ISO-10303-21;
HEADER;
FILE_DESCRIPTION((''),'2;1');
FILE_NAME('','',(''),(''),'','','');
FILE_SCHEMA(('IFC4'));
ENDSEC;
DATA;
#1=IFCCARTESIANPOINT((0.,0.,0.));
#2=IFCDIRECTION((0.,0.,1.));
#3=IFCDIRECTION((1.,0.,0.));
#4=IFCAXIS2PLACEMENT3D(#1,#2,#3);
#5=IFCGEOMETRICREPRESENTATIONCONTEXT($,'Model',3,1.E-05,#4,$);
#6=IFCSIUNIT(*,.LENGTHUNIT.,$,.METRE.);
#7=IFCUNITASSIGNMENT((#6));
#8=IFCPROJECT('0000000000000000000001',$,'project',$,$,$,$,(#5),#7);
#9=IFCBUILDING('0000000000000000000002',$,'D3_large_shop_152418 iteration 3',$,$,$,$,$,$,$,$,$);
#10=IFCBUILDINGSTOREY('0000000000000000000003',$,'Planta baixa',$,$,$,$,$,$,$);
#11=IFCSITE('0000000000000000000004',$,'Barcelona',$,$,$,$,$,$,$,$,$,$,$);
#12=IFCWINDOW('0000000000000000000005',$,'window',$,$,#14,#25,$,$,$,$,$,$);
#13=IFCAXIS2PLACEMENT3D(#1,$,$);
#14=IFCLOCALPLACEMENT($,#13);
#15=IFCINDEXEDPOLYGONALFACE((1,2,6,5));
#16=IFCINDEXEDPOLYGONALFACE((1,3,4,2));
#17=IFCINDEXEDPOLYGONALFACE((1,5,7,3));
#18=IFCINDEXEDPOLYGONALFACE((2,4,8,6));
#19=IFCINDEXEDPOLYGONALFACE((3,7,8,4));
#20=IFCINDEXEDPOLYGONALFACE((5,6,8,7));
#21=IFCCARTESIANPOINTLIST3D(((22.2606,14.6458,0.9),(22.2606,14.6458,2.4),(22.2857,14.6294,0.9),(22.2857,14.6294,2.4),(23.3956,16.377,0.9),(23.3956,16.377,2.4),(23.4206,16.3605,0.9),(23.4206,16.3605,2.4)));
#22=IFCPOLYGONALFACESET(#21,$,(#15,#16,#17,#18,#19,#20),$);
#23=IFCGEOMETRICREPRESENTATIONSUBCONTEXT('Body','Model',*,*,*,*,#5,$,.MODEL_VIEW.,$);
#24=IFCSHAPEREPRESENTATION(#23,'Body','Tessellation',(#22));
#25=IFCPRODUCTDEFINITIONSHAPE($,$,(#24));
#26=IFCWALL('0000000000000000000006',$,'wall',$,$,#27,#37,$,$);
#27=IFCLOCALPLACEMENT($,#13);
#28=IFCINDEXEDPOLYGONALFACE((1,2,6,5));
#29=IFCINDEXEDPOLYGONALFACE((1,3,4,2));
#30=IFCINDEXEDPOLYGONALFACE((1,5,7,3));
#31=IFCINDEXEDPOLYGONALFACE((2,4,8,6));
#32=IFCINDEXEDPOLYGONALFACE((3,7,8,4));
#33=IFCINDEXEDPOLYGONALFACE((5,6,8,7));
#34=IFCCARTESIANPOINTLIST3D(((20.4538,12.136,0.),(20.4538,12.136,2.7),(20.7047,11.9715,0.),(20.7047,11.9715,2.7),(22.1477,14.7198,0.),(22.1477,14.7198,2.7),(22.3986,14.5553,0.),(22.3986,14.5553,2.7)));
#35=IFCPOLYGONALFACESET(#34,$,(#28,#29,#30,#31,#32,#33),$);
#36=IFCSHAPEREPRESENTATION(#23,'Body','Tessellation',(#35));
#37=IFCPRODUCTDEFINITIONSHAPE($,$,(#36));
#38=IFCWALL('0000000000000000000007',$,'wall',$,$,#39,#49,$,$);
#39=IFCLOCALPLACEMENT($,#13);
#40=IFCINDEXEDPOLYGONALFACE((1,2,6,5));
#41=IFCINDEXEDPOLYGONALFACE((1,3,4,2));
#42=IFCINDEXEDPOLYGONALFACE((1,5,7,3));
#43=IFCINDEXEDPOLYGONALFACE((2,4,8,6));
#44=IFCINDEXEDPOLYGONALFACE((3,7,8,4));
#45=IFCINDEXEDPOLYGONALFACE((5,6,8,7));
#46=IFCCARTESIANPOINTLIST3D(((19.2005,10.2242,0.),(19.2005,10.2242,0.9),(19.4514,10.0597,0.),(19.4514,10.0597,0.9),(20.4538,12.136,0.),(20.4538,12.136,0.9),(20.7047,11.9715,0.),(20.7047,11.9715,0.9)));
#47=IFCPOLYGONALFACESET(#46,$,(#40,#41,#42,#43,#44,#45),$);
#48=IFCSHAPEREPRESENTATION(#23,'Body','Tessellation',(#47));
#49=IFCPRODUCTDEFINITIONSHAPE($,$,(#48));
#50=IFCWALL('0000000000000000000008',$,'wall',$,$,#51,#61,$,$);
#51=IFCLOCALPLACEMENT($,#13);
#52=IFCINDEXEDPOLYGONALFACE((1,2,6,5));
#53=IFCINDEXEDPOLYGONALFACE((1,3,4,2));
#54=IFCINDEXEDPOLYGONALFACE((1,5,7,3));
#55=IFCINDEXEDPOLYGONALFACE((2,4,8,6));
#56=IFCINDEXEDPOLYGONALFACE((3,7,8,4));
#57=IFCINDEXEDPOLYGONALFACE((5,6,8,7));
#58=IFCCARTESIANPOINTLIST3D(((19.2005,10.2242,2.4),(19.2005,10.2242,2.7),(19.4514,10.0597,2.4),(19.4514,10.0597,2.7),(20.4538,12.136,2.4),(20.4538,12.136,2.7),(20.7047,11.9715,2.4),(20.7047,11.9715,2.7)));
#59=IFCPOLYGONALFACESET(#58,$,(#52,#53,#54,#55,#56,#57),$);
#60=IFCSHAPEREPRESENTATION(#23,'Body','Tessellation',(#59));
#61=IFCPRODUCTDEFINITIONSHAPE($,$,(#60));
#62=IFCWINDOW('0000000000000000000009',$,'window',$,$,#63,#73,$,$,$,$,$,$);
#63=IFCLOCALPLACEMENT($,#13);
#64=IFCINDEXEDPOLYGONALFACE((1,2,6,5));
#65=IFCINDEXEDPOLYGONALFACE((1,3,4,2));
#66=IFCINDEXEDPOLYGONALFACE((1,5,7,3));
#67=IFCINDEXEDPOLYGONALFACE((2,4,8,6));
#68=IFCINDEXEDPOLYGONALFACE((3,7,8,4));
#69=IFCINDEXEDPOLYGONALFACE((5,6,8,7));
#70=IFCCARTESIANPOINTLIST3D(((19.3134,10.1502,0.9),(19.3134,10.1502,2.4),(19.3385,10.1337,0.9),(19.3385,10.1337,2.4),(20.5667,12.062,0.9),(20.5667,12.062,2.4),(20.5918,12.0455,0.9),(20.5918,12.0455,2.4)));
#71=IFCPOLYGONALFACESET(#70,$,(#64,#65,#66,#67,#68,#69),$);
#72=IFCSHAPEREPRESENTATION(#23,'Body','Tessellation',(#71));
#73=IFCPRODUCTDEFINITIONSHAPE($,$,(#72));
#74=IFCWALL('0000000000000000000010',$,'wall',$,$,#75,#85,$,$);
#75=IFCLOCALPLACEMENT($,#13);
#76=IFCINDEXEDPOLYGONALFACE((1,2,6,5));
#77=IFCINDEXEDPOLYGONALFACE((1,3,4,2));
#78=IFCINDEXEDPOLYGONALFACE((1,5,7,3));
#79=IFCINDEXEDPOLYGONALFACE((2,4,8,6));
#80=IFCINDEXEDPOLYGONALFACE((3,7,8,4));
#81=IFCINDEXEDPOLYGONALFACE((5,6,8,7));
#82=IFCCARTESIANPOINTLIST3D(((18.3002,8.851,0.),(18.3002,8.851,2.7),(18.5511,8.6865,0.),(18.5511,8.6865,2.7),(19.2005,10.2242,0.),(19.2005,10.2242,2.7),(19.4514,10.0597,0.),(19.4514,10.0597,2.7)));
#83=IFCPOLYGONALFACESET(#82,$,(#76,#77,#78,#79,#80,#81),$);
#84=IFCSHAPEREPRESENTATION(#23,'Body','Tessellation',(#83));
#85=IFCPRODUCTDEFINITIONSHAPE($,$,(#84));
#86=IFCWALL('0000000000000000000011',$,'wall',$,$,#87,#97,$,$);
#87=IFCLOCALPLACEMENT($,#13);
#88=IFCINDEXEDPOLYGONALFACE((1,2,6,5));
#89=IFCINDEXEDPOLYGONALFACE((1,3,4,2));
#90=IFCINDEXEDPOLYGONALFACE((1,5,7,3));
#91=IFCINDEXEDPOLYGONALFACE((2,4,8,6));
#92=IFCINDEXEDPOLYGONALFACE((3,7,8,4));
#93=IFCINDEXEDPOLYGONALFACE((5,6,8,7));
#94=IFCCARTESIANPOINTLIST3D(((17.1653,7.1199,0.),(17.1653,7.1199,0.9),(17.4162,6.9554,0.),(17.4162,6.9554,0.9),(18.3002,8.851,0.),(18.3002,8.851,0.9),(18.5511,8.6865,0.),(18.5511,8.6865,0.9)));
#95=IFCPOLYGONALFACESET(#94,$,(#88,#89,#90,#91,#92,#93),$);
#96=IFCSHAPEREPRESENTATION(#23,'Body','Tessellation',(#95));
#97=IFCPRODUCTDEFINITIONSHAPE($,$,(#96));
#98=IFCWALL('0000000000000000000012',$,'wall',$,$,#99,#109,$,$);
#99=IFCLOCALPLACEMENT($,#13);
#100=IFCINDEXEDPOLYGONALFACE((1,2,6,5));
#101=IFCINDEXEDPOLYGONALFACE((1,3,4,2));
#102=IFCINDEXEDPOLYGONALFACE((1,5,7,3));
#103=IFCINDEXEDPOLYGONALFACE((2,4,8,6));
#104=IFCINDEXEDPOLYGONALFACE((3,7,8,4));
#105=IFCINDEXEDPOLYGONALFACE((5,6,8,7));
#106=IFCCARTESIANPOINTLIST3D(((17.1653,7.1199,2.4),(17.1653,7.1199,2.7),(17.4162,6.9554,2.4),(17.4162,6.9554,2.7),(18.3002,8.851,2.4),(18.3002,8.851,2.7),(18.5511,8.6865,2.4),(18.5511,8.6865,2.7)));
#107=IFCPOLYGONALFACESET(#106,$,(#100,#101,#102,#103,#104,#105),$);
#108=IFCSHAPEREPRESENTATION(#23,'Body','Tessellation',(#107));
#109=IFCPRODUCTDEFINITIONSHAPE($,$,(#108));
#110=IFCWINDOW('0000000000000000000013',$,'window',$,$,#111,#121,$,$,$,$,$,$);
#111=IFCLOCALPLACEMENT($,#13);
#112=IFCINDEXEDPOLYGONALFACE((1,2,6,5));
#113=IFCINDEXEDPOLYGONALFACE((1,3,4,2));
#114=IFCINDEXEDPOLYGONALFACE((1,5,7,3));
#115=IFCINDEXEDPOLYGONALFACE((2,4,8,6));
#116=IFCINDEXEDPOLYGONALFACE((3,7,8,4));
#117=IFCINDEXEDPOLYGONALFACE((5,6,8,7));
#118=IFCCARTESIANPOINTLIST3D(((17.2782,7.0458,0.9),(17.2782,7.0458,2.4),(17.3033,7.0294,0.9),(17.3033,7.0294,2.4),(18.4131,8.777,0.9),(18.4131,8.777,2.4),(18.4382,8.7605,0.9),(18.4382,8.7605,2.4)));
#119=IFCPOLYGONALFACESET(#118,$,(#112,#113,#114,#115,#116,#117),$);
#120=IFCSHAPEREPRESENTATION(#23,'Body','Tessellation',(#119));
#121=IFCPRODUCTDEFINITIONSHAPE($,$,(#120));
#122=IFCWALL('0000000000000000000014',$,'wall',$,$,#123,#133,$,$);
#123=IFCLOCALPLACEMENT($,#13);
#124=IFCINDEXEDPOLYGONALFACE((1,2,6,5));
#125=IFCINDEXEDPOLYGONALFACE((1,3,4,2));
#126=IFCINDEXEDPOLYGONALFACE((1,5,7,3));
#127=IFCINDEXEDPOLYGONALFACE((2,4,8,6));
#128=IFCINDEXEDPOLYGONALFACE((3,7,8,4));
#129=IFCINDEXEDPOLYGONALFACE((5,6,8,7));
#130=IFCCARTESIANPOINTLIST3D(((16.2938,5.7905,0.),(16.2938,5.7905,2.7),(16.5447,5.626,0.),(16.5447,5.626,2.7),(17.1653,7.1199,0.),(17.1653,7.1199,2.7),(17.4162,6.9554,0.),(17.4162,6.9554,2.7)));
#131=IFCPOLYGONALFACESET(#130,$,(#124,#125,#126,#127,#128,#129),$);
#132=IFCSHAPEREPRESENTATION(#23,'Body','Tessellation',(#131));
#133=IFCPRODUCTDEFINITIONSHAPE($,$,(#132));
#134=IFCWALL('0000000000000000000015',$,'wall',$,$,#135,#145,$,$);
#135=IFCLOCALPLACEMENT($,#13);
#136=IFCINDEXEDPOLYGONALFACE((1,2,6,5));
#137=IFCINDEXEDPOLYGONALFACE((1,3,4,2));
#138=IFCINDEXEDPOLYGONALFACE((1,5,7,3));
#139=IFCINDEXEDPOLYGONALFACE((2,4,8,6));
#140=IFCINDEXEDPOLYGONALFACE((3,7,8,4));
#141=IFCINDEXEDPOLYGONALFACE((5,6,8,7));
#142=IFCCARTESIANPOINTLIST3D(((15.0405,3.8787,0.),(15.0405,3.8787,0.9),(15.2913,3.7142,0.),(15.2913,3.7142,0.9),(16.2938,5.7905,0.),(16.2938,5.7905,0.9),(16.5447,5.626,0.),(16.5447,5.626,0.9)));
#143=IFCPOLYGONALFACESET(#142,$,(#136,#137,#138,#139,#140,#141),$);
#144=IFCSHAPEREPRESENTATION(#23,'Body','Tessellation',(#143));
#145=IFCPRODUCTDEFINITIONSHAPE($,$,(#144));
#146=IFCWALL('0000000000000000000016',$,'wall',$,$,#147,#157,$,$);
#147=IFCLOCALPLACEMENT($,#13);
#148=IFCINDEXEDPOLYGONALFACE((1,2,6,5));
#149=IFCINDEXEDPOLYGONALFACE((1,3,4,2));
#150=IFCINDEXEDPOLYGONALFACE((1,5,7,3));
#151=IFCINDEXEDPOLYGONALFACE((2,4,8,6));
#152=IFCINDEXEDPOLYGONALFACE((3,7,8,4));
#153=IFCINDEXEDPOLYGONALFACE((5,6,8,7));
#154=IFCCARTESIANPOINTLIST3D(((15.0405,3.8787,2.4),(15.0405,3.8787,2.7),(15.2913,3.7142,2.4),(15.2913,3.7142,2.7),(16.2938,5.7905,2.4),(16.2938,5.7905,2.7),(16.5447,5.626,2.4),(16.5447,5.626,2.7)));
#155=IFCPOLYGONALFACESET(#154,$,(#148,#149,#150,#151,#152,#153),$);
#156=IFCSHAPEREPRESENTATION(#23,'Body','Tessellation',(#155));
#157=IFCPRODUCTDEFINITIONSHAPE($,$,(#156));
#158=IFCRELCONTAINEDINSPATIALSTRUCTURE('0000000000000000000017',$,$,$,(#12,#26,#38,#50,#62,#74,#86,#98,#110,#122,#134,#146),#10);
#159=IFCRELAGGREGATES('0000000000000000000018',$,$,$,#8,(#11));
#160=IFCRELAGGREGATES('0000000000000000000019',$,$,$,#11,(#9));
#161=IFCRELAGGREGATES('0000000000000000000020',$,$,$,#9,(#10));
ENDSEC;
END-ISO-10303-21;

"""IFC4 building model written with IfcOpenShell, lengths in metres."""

from ifc_helpers import new_model, si_unit, frame, origin, origin_with_axes, place, context, subcontext, project, spatial, polyline, outline, extrude, element, save


model = new_model("IFC4")

# Units and contexts
model_context = context("Model", 3, precision=1e-05, world=origin_with_axes())
body_context = subcontext(model_context, "Body", "Model", "MODEL_VIEW")
ifc_project = project(units=[si_unit("LENGTHUNIT", "METRE")], contexts=[model_context])

# Site, building, storey
site = spatial("IfcSite", under=ifc_project, Name="Barcelona")
building = spatial("IfcBuilding", under=site, Name="D3_large_shop_152418 iteration 3")
storey = spatial("IfcBuildingStorey", under=building, Name="Planta baixa")

# Window
window_1_placement = place(None, origin_with_axes())
element("IfcWindow", 1, at=window_1_placement, inside=storey, Name="window", context=body_context, shape_type="SweptSolid", body=[
    extrude(outline(polyline([(23.4206, 16.3605), (22.2857, 14.6294), (22.2606, 14.6458), (23.3956, 16.377), (23.4206, 16.3605)])), frame((0.0, 0.0, 0.9)), (0.0, 0.0, 1.0), 1.5),
])

# Walls
wall_1_placement = place(None, origin_with_axes())
element("IfcWall", 2, at=wall_1_placement, inside=storey, Name="wall", context=body_context, shape_type="SweptSolid", body=[
    extrude(outline(polyline([(22.3986, 14.5553), (20.7047, 11.9715), (20.4538, 12.136), (22.1477, 14.7198), (22.3986, 14.5553)])), origin(), (0.0, 0.0, 1.0), 2.7),
])
wall_2_placement = place(None, origin_with_axes())
element("IfcWall", 3, at=wall_2_placement, inside=storey, Name="wall", context=body_context, shape_type="SweptSolid", body=[
    extrude(outline(polyline([(20.7047, 11.9715), (19.4514, 10.0597), (19.2005, 10.2242), (20.4538, 12.136), (20.7047, 11.9715)])), origin(), (0.0, 0.0, 1.0), 0.9),
])
wall_3_placement = place(None, origin_with_axes())
element("IfcWall", 4, at=wall_3_placement, inside=storey, Name="wall", context=body_context, shape_type="SweptSolid", body=[
    extrude(outline(polyline([(20.7047, 11.9715), (19.4514, 10.0597), (19.2005, 10.2242), (20.4538, 12.136), (20.7047, 11.9715)])), frame((0.0, 0.0, 2.4)), (0.0, 0.0, 1.0), 0.3),
])

# Window
window_2_placement = place(None, origin_with_axes())
element("IfcWindow", 5, at=window_2_placement, inside=storey, Name="window", context=body_context, shape_type="SweptSolid", body=[
    extrude(outline(polyline([(20.5918, 12.0455), (19.3385, 10.1337), (19.3134, 10.1502), (20.5667, 12.062), (20.5918, 12.0455)])), frame((0.0, 0.0, 0.9)), (0.0, 0.0, 1.0), 1.5),
])

# Walls
wall_4_placement = place(None, origin_with_axes())
element("IfcWall", 6, at=wall_4_placement, inside=storey, Name="wall", context=body_context, shape_type="SweptSolid", body=[
    extrude(outline(polyline([(19.4514, 10.0597), (18.5511, 8.6865), (18.3002, 8.851), (19.2005, 10.2242), (19.4514, 10.0597)])), origin(), (0.0, 0.0, 1.0), 2.7),
])
wall_5_placement = place(None, origin_with_axes())
element("IfcWall", 7, at=wall_5_placement, inside=storey, Name="wall", context=body_context, shape_type="SweptSolid", body=[
    extrude(outline(polyline([(18.5511, 8.6865), (17.4162, 6.9554), (17.1653, 7.1199), (18.3002, 8.851), (18.5511, 8.6865)])), origin(), (0.0, 0.0, 1.0), 0.9),
])
wall_6_placement = place(None, origin_with_axes())
element("IfcWall", 8, at=wall_6_placement, inside=storey, Name="wall", context=body_context, shape_type="SweptSolid", body=[
    extrude(outline(polyline([(18.5511, 8.6865), (17.4162, 6.9554), (17.1653, 7.1199), (18.3002, 8.851), (18.5511, 8.6865)])), frame((0.0, 0.0, 2.4)), (0.0, 0.0, 1.0), 0.3),
])

# Window
window_3_placement = place(None, origin_with_axes())
element("IfcWindow", 9, at=window_3_placement, inside=storey, Name="window", context=body_context, shape_type="SweptSolid", body=[
    extrude(outline(polyline([(18.4382, 8.7605), (17.3033, 7.0294), (17.2782, 7.0458), (18.4131, 8.777), (18.4382, 8.7605)])), frame((0.0, 0.0, 0.9)), (0.0, 0.0, 1.0), 1.5),
])

# Walls
wall_7_placement = place(None, origin_with_axes())
element("IfcWall", 10, at=wall_7_placement, inside=storey, Name="wall", context=body_context, shape_type="SweptSolid", body=[
    extrude(outline(polyline([(17.4162, 6.9554), (16.5447, 5.626), (16.2938, 5.7905), (17.1653, 7.1199), (17.4162, 6.9554)])), origin(), (0.0, 0.0, 1.0), 2.7),
])
wall_8_placement = place(None, origin_with_axes())
element("IfcWall", 11, at=wall_8_placement, inside=storey, Name="wall", context=body_context, shape_type="SweptSolid", body=[
    extrude(outline(polyline([(16.5447, 5.626), (15.2913, 3.7142), (15.0405, 3.8787), (16.2938, 5.7905), (16.5447, 5.626)])), origin(), (0.0, 0.0, 1.0), 0.9),
])
wall_9_placement = place(None, origin_with_axes())
element("IfcWall", 12, at=wall_9_placement, inside=storey, Name="wall", context=body_context, shape_type="SweptSolid", body=[
    extrude(outline(polyline([(16.5447, 5.626), (15.2913, 3.7142), (15.0405, 3.8787), (16.2938, 5.7905), (16.5447, 5.626)])), frame((0.0, 0.0, 2.4)), (0.0, 0.0, 1.0), 0.3),
])

save(model, "model.ifc")
